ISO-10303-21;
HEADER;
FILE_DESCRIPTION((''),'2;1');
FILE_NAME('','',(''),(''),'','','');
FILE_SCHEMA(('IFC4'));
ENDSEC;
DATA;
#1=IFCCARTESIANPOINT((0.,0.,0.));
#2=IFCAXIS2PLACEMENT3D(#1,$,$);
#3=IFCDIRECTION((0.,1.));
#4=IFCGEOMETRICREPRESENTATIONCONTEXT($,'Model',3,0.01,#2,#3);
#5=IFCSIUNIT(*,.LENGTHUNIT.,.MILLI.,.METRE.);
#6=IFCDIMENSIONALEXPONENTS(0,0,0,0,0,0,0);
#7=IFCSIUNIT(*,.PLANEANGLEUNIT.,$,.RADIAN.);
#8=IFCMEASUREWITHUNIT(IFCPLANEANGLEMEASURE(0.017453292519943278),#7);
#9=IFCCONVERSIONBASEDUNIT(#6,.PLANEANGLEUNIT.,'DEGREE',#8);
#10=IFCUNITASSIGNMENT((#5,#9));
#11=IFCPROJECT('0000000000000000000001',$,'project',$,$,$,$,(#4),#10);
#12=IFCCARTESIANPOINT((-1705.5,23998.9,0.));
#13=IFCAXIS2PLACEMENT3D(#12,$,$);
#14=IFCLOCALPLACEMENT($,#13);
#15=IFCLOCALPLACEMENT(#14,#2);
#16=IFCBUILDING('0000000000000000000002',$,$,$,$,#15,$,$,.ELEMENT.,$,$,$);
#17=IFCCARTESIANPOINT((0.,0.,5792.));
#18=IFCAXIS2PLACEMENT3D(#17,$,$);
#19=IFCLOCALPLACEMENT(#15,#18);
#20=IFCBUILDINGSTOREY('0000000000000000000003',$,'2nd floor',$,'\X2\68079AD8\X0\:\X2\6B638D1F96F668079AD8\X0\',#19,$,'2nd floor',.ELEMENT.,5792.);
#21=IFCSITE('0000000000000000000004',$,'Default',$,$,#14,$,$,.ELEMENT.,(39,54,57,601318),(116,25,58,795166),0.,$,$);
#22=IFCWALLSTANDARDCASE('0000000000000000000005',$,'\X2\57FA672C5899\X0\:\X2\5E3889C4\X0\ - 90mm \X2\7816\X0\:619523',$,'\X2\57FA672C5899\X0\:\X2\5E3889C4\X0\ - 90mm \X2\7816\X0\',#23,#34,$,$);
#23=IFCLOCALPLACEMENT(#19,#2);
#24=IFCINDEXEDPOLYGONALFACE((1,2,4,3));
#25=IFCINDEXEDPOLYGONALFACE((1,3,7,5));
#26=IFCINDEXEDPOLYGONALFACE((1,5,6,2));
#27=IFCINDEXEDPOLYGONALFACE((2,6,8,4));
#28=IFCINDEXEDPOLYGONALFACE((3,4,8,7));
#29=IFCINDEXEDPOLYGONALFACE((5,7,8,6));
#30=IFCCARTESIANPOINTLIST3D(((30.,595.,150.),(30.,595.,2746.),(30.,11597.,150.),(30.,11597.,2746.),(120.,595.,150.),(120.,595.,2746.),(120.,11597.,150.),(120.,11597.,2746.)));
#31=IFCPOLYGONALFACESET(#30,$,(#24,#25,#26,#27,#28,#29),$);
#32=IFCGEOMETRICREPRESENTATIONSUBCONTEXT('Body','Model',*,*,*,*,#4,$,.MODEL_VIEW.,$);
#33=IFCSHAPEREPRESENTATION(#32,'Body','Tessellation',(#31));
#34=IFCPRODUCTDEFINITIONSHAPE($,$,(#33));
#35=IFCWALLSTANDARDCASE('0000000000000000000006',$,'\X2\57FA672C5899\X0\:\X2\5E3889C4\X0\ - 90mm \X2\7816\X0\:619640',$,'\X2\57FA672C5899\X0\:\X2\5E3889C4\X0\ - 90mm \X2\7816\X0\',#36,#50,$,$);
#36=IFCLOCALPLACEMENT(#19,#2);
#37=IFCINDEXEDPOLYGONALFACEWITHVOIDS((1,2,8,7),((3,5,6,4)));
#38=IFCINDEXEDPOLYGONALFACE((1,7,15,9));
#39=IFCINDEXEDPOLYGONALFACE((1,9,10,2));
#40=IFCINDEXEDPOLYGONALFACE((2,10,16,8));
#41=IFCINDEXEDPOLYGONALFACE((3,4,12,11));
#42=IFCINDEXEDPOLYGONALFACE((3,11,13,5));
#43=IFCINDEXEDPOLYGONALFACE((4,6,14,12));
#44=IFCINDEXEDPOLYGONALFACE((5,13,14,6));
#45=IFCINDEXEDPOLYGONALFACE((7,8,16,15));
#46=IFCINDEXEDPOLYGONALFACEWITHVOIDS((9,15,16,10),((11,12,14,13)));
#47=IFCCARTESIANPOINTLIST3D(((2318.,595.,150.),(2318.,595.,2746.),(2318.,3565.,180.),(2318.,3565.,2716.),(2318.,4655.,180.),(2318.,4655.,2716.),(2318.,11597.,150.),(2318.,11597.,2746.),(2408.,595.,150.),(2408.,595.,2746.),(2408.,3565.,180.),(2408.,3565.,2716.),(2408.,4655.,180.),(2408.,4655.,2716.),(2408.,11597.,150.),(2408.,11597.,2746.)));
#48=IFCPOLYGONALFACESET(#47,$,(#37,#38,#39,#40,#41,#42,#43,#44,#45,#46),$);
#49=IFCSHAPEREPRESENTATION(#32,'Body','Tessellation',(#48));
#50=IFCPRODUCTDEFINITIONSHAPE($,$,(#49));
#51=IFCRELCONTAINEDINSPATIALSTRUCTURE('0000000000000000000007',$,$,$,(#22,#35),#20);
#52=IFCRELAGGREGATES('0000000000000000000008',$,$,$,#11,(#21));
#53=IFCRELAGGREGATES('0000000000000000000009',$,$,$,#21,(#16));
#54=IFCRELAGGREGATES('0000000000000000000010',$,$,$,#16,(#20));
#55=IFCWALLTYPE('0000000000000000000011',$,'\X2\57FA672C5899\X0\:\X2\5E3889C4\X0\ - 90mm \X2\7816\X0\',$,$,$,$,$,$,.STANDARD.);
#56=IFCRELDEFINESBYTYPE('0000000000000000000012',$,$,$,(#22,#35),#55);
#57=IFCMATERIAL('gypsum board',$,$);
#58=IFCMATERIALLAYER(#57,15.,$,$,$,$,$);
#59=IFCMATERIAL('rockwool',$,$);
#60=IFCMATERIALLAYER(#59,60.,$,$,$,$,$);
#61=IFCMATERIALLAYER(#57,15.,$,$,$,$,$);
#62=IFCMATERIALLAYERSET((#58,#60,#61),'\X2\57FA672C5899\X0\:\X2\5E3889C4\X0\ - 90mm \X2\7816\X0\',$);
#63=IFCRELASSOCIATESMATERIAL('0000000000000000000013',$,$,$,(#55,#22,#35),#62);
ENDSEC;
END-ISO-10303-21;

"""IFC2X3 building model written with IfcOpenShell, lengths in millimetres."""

from ifc_helpers import new_model, entity, si_unit, converted_unit, direction, frame, frame_2d, origin, place, context, subcontext, project, spatial, rectangle, extrude, material, layer, layer_set, layer_usage, type_object, element, save


model = new_model("IFC2X3")

# Units and contexts
model_context = context("Model", 3, precision=0.01, world=origin(), true_north=direction((0.0, 1.0)))
body_context = subcontext(model_context, "Body", "Model", "MODEL_VIEW")
ifc_project = project(units=[si_unit("LENGTHUNIT", "METRE", prefix="MILLI"), converted_unit("PLANEANGLEUNIT", "DEGREE", entity("IfcPlaneAngleMeasure", 0.017453292519943278), si_unit("PLANEANGLEUNIT", "RADIAN"), dimensions=[0, 0, 0, 0, 0, 0, 0])], contexts=[model_context])

# Site, building, storey
site_placement = place(None, frame((-1705.5, 23998.9, 0.0)))
site = spatial("IfcSite", under=ifc_project, at=site_placement, Name="Default", CompositionType="ELEMENT", RefLatitude=(39, 54, 57, 601318), RefLongitude=(116, 25, 58, 795166), RefElevation=0.0)
building_placement = place(site_placement, origin())
building = spatial("IfcBuilding", under=site, at=building_placement, CompositionType="ELEMENT")
storey_placement = place(building_placement, frame((0.0, 0.0, 5792.0)))
storey = spatial("IfcBuildingStorey", under=building, at=storey_placement, Name="2nd floor", ObjectType="标高:正负零标高", LongName="2nd floor", CompositionType="ELEMENT", Elevation=5792.0)

# Wall
ifc_material_1 = material(Name="gypsum board")
ifc_layer_1 = layer(ifc_material_1, 15.0)
ifc_material_2 = material(Name="rockwool")
ifc_layer_2 = layer(ifc_material_2, 60.0)
ifc_layer_3 = layer(ifc_material_1, 15.0)
ifc_layer_set = layer_set([ifc_layer_1, ifc_layer_2, ifc_layer_3], Name="基本墙:常规 - 90mm 砖")
ifc_layer_usage_1 = layer_usage(ifc_layer_set, "AXIS2", "NEGATIVE", 45.0)
wall_type = type_object("IfcWallType", Name="基本墙:常规 - 90mm 砖", PredefinedType="STANDARD", material=ifc_layer_set)
wall_1_placement = place(storey_placement, frame((75.0, 11597.0, 150.0), z_axis=(0.0, 0.0, 1.0), x_axis=(0.0, -1.0, 0.0)))
element("IfcWallStandardCase", 1, at=wall_1_placement, inside=storey, type_object=wall_type, material=ifc_layer_usage_1, Name="基本墙:常规 - 90mm 砖:619523", ObjectType="基本墙:常规 - 90mm 砖", context=body_context, shape_type="SweptSolid", body=[
    extrude(rectangle(XDim=11002.0, YDim=90.0, at=frame_2d((5501.0, 0.0), x_axis=(-1.0, 0.0))), origin(), (0.0, 0.0, 1.0), 2596.0),
])

# Wall, opening
ifc_layer_usage_2 = layer_usage(ifc_layer_set, "AXIS2", "NEGATIVE", 45.0)
wall_2_placement = place(storey_placement, frame((2363.0, 11597.0, 150.0), z_axis=(0.0, 0.0, 1.0), x_axis=(0.0, -1.0, 0.0)))
wall_2 = element("IfcWallStandardCase", 2, at=wall_2_placement, inside=storey, type_object=wall_type, material=ifc_layer_usage_2, Name="基本墙:常规 - 90mm 砖:619640", ObjectType="基本墙:常规 - 90mm 砖", context=body_context, shape_type="SweptSolid", body=[
    extrude(rectangle(XDim=11002.0, YDim=90.0, at=frame_2d((5501.0, 0.0), x_axis=(-1.0, 0.0))), origin(), (0.0, 0.0, 1.0), 2596.0),
])
opening_1_placement = place(wall_2_placement, origin())
element("IfcOpeningElement", 3, at=opening_1_placement, cuts=wall_2, ObjectType="Opening", context=body_context, shape_type="SweptSolid", body=[
    extrude(rectangle(XDim=2536.0, YDim=1090.0, at=frame_2d((0.0, 0.0), x_axis=(0.0, 1.0))), frame((7487.0, 45.0, 1298.0), z_axis=(0.0, -1.0, 0.0), x_axis=(-1.0, 0.0, 0.0)), (0.0, 0.0, 1.0), 90.0),
])

save(model, "model.ifc")
